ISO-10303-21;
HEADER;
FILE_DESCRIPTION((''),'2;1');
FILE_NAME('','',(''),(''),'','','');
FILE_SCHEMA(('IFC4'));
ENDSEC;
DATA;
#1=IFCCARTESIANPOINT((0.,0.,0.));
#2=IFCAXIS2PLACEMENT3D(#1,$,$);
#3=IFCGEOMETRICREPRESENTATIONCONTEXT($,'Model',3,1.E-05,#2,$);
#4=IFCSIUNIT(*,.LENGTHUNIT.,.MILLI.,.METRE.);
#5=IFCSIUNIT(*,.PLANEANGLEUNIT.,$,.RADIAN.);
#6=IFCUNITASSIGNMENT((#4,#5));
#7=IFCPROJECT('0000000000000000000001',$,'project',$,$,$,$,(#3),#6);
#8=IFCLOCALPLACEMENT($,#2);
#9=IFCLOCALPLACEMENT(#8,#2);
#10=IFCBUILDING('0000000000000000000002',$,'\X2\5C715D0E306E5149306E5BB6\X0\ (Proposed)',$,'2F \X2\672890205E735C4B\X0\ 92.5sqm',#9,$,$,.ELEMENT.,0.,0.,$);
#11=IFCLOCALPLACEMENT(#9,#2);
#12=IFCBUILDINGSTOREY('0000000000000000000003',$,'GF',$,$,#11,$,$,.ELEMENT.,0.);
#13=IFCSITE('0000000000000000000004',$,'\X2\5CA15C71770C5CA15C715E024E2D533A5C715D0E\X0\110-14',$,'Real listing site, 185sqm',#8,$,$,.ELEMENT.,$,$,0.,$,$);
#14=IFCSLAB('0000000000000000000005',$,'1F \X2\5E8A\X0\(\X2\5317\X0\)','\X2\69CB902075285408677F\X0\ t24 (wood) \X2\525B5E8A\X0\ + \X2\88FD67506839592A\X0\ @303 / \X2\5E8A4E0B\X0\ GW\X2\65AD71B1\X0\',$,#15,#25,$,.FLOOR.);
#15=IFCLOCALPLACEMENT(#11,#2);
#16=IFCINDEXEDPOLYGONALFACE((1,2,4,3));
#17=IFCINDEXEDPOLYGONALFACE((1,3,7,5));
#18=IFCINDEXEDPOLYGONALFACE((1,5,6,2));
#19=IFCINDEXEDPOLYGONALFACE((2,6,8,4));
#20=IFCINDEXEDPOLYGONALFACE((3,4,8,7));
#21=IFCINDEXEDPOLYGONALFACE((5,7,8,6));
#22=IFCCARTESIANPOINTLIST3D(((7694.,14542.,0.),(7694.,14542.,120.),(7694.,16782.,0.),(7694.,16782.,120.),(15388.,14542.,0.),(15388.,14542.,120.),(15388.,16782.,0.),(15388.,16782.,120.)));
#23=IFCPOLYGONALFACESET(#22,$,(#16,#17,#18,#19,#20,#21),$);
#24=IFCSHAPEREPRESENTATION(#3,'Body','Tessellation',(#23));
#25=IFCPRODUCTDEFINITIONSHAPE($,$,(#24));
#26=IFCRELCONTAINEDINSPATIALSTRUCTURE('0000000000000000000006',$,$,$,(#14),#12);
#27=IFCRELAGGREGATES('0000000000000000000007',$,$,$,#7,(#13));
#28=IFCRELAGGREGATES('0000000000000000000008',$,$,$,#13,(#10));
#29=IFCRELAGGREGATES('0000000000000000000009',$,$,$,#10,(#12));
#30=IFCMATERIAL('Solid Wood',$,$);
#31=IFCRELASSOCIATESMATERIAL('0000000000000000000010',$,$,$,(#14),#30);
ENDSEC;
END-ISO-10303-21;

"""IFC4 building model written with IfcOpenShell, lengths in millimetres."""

from ifc_helpers import new_model, si_unit, frame, frame_2d, origin, place, context, project, spatial, rectangle, extrude, material, element, save


model = new_model("IFC4")

# Units and contexts
model_context = context("Model", 3, precision=1e-05, world=origin())
ifc_project = project(units=[si_unit("LENGTHUNIT", "METRE", prefix="MILLI"), si_unit("PLANEANGLEUNIT", "RADIAN")], contexts=[model_context])

# Site, building, storey
site_placement = place(None, origin())
site = spatial("IfcSite", under=ifc_project, at=site_placement, Name="岡山県岡山市中区山崎110-14", ObjectType="Real listing site, 185sqm", CompositionType="ELEMENT", RefElevation=0.0)
building_placement = place(site_placement, origin())
building = spatial("IfcBuilding", under=site, at=building_placement, Name="山崎の光の家 (Proposed)", ObjectType="2F 木造平屋 92.5sqm", CompositionType="ELEMENT", ElevationOfRefHeight=0.0, ElevationOfTerrain=0.0)
storey_placement = place(building_placement, origin())
storey = spatial("IfcBuildingStorey", under=building, at=storey_placement, Name="GF", CompositionType="ELEMENT", Elevation=0.0)

# Slab
ifc_material_1 = material(Name="Solid Wood")
slab_1_placement = place(storey_placement, frame((3847.0, 7271.0, 0.0)))
element("IfcSlab", 1, at=slab_1_placement, inside=storey, material=ifc_material_1, Name="1F 床(北)", Description="構造用合板 t24 (wood) 剛床 + 製材根太 @303 / 床下 GW断熱", PredefinedType="FLOOR", context=model_context, shape_type="SweptSolid", body=[
    extrude(rectangle(XDim=7694.0, YDim=2240.0, at=frame_2d((3847.0, 1120.0))), frame((3847.0, 7271.0, 0.0)), (0.0, 0.0, 1.0), 120.0),
])

save(model, "model.ifc")
